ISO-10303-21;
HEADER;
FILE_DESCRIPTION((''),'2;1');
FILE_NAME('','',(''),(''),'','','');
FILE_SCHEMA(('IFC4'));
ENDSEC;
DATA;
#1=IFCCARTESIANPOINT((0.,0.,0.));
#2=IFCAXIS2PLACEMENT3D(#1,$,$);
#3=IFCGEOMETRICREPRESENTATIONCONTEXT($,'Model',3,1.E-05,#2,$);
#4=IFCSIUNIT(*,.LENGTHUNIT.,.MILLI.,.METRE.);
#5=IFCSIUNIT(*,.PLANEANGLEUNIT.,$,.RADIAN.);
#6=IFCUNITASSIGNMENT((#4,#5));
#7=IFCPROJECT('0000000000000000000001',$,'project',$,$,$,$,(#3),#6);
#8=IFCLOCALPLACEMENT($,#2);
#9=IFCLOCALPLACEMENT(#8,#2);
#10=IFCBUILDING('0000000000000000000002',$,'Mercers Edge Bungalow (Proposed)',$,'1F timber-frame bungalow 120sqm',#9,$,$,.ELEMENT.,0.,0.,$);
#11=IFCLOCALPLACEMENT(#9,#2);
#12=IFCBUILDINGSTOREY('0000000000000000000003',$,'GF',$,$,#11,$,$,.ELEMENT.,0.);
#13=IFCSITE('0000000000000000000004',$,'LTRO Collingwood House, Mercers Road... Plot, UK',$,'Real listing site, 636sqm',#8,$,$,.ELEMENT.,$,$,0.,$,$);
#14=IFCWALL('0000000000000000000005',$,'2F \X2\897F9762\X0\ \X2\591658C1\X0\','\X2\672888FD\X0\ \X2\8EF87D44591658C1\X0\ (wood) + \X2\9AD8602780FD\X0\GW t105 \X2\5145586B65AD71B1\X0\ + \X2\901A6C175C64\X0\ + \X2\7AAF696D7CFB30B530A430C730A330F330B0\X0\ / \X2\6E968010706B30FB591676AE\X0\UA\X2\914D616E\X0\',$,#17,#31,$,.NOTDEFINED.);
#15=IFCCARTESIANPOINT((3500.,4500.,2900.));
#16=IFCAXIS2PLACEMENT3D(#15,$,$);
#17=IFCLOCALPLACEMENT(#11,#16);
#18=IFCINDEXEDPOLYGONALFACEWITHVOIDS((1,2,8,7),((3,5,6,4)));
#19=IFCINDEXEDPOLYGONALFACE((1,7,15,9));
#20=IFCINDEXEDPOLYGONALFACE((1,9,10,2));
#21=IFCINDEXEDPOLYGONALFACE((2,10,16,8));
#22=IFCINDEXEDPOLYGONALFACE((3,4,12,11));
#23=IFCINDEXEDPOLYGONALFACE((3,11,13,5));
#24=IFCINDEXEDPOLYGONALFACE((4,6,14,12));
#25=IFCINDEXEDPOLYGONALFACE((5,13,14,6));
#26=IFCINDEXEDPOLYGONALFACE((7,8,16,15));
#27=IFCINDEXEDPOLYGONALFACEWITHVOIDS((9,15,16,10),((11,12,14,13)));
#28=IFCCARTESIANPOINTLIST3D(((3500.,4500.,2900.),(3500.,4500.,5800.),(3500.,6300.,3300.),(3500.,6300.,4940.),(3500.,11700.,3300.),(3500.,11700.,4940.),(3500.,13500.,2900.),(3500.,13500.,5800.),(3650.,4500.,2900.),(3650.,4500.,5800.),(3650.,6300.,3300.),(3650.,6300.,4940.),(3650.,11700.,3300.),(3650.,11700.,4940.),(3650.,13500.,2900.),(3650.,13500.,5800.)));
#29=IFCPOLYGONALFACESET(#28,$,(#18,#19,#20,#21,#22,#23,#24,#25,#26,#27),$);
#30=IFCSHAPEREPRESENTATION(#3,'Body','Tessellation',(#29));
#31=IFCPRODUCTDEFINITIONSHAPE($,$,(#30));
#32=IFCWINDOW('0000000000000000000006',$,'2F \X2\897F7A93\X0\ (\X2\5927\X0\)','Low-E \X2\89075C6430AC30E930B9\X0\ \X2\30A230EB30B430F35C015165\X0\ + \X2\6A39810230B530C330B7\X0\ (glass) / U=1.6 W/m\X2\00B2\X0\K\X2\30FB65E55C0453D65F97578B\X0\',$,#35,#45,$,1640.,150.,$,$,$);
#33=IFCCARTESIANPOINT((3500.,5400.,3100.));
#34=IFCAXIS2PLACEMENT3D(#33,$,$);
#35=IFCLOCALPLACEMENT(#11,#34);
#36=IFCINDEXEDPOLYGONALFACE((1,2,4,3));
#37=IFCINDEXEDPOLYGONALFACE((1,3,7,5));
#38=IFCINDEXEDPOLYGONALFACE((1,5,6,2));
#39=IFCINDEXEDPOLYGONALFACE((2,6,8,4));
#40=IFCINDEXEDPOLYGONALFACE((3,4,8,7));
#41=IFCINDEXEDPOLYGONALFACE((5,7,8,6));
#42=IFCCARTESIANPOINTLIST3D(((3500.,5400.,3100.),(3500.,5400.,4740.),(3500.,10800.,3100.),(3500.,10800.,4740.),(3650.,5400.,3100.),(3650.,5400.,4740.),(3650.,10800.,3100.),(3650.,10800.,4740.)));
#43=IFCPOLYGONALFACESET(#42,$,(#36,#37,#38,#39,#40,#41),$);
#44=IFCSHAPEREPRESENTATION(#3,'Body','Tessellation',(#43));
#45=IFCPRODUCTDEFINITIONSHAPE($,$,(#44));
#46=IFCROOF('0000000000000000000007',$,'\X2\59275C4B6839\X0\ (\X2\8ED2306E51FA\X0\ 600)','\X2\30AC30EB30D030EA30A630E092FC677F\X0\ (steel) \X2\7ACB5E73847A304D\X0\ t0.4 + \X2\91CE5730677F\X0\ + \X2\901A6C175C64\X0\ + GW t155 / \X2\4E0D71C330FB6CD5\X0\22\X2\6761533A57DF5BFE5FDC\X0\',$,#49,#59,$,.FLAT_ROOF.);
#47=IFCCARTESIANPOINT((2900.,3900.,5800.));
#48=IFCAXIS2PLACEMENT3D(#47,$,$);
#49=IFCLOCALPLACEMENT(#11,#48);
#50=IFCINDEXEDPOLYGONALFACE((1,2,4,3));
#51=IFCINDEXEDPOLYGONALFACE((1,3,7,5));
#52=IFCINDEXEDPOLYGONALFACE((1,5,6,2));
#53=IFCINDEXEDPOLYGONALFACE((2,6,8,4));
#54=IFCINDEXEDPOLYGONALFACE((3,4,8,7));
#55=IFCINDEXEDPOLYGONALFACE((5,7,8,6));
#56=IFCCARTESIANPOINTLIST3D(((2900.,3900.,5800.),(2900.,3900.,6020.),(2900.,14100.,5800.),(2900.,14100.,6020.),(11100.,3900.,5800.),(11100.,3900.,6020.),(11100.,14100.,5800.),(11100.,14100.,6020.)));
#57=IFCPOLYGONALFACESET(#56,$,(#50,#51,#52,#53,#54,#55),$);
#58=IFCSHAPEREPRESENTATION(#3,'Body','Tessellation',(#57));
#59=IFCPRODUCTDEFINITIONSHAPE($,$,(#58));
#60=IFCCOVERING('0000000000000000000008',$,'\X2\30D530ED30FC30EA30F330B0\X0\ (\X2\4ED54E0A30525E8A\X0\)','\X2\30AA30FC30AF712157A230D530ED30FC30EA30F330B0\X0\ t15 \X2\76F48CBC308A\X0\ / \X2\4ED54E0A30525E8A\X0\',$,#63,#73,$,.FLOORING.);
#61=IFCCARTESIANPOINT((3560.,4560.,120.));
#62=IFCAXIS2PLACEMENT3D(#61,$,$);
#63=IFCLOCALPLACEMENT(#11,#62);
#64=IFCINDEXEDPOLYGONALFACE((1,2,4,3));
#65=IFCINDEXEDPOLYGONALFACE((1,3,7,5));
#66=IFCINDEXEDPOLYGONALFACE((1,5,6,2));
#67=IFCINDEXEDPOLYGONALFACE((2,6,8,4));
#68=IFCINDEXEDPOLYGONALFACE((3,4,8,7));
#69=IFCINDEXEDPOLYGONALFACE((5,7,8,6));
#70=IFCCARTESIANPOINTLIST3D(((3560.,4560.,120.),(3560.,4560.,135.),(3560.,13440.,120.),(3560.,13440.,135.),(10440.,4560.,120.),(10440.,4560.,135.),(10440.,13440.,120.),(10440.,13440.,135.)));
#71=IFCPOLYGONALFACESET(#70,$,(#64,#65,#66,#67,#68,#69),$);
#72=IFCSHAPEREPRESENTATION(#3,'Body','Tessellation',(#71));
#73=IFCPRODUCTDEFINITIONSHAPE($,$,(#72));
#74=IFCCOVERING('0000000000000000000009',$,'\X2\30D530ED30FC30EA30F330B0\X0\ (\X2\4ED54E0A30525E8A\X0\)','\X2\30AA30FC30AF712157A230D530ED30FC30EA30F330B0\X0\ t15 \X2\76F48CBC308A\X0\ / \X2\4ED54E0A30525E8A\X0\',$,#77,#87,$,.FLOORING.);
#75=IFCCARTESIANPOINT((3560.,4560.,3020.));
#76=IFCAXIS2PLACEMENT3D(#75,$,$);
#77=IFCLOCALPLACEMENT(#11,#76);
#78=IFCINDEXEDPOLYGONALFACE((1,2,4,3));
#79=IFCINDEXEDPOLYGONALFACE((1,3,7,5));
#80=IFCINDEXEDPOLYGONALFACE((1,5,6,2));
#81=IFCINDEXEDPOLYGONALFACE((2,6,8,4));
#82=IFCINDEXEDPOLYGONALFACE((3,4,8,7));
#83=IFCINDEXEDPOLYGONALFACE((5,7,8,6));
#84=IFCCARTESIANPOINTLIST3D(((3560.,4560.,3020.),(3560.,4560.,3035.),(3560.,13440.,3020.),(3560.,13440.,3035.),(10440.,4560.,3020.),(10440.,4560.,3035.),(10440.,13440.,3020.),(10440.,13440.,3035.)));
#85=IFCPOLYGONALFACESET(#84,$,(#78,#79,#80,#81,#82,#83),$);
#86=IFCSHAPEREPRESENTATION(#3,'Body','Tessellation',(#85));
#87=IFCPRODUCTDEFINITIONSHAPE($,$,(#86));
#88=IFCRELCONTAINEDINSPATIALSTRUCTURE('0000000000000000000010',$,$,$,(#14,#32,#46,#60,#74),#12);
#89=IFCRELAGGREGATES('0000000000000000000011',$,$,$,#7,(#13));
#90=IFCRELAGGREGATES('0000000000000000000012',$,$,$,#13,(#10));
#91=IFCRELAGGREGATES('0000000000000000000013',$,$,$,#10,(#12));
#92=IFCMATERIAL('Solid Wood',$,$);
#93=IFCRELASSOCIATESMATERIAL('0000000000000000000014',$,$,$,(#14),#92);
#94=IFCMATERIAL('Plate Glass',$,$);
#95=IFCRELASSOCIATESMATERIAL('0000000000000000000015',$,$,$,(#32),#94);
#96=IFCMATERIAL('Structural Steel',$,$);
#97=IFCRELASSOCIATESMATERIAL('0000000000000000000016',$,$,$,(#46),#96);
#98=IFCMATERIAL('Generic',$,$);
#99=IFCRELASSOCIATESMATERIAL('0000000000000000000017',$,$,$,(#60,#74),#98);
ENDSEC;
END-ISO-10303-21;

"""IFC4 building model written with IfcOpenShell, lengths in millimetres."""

from ifc_helpers import new_model, si_unit, frame, frame_2d, origin, place, context, project, spatial, rectangle, extrude, material, element, fill, save


model = new_model("IFC4")

# Units and contexts
model_context = context("Model", 3, precision=1e-05, world=origin())
ifc_project = project(units=[si_unit("LENGTHUNIT", "METRE", prefix="MILLI"), si_unit("PLANEANGLEUNIT", "RADIAN")], contexts=[model_context])

# Site, building, storey
site_placement = place(None, origin())
site = spatial("IfcSite", under=ifc_project, at=site_placement, Name="LTRO Collingwood House, Mercers Road... Plot, UK", ObjectType="Real listing site, 636sqm", CompositionType="ELEMENT", RefElevation=0.0)
building_placement = place(site_placement, origin())
building = spatial("IfcBuilding", under=site, at=building_placement, Name="Mercers Edge Bungalow (Proposed)", ObjectType="1F timber-frame bungalow 120sqm", CompositionType="ELEMENT", ElevationOfRefHeight=0.0, ElevationOfTerrain=0.0)
storey_placement = place(building_placement, origin())
storey = spatial("IfcBuildingStorey", under=building, at=storey_placement, Name="GF", CompositionType="ELEMENT", Elevation=0.0)

# Shared definitions
ifc_material_1 = material(Name="Solid Wood")
ifc_material_2 = material(Name="Generic")

# Shared definitions
ifc_material_3 = material(Name="Plate Glass")

# Wall, opening, window
wall_1_placement = place(storey_placement, frame((3500.0, 4500.0, 2900.0)))
wall_1 = element("IfcWall", 1, at=wall_1_placement, inside=storey, material=ifc_material_1, Name="2F 西面 外壁", Description="木製 軸組外壁 (wood) + 高性能GW t105 充填断熱 + 通気層 + 窯業系サイディング / 準耐火・外皮UA配慮", PredefinedType="NOTDEFINED", context=model_context, shape_type="SweptSolid", body=[
    extrude(rectangle(XDim=150.0, YDim=9000.0, at=frame_2d((75.0, 4500.0))), frame((3500.0, 4500.0, 2900.0)), (0.0, 0.0, 1.0), 2900.0),
])
opening_1_placement = place(storey_placement, frame((3500.0, 5400.0, 3100.0)))
opening_1 = element("IfcOpeningElement", 2, at=opening_1_placement, cuts=wall_1, PredefinedType="NOTDEFINED", context=model_context, shape_type="SweptSolid", body=[
    extrude(rectangle(XDim=150.0, YDim=5400.0, at=frame_2d((75.0, 2700.0))), frame((3500.0, 5400.0, 3100.0)), (0.0, 0.0, 1.0), 1640.0),
])
window_1_placement = place(storey_placement, frame((3500.0, 5400.0, 3100.0)))
window_1 = element("IfcWindow", 3, at=window_1_placement, inside=storey, material=ifc_material_3, Name="2F 西窓 (大)", Description="Low-E 複層ガラス アルゴン封入 + 樹脂サッシ (glass) / U=1.6 W/m²K・日射取得型", OverallHeight=1640.0, OverallWidth=150.0, context=model_context, shape_type="SweptSolid", body=[
    extrude(rectangle(XDim=150.0, YDim=5400.0, at=frame_2d((75.0, 2700.0))), frame((3500.0, 5400.0, 3100.0)), (0.0, 0.0, 1.0), 1640.0),
])
fill(opening_1, window_1)

# Roof
ifc_material_4 = material(Name="Structural Steel")
roof_placement = place(storey_placement, frame((2900.0, 3900.0, 5800.0)))
element("IfcRoof", 4, at=roof_placement, inside=storey, material=ifc_material_4, Name="大屋根 (軒の出 600)", Description="ガルバリウム鋼板 (steel) 立平葺き t0.4 + 野地板 + 通気層 + GW t155 / 不燃・法22条区域対応", PredefinedType="FLAT_ROOF", context=model_context, shape_type="SweptSolid", body=[
    extrude(rectangle(XDim=8200.0, YDim=10200.0, at=frame_2d((4100.0, 5100.0))), frame((2900.0, 3900.0, 5800.0)), (0.0, 0.0, 1.0), 220.0),
])

# Coverings
covering_1_placement = place(storey_placement, frame((3560.0, 4560.0, 120.0)))
element("IfcCovering", 5, at=covering_1_placement, inside=storey, material=ifc_material_2, Name="フローリング (仕上げ床)", Description="オーク無垢フローリング t15 直貼り / 仕上げ床", PredefinedType="FLOORING", context=model_context, shape_type="SweptSolid", body=[
    extrude(rectangle(XDim=6880.0, YDim=8880.0, at=frame_2d((3440.0, 4440.0))), frame((3560.0, 4560.0, 120.0)), (0.0, 0.0, 1.0), 15.0),
])
covering_2_placement = place(storey_placement, frame((3560.0, 4560.0, 3020.0)))
element("IfcCovering", 6, at=covering_2_placement, inside=storey, material=ifc_material_2, Name="フローリング (仕上げ床)", Description="オーク無垢フローリング t15 直貼り / 仕上げ床", PredefinedType="FLOORING", context=model_context, shape_type="SweptSolid", body=[
    extrude(rectangle(XDim=6880.0, YDim=8880.0, at=frame_2d((3440.0, 4440.0))), frame((3560.0, 4560.0, 3020.0)), (0.0, 0.0, 1.0), 15.0),
])

save(model, "model.ifc")
